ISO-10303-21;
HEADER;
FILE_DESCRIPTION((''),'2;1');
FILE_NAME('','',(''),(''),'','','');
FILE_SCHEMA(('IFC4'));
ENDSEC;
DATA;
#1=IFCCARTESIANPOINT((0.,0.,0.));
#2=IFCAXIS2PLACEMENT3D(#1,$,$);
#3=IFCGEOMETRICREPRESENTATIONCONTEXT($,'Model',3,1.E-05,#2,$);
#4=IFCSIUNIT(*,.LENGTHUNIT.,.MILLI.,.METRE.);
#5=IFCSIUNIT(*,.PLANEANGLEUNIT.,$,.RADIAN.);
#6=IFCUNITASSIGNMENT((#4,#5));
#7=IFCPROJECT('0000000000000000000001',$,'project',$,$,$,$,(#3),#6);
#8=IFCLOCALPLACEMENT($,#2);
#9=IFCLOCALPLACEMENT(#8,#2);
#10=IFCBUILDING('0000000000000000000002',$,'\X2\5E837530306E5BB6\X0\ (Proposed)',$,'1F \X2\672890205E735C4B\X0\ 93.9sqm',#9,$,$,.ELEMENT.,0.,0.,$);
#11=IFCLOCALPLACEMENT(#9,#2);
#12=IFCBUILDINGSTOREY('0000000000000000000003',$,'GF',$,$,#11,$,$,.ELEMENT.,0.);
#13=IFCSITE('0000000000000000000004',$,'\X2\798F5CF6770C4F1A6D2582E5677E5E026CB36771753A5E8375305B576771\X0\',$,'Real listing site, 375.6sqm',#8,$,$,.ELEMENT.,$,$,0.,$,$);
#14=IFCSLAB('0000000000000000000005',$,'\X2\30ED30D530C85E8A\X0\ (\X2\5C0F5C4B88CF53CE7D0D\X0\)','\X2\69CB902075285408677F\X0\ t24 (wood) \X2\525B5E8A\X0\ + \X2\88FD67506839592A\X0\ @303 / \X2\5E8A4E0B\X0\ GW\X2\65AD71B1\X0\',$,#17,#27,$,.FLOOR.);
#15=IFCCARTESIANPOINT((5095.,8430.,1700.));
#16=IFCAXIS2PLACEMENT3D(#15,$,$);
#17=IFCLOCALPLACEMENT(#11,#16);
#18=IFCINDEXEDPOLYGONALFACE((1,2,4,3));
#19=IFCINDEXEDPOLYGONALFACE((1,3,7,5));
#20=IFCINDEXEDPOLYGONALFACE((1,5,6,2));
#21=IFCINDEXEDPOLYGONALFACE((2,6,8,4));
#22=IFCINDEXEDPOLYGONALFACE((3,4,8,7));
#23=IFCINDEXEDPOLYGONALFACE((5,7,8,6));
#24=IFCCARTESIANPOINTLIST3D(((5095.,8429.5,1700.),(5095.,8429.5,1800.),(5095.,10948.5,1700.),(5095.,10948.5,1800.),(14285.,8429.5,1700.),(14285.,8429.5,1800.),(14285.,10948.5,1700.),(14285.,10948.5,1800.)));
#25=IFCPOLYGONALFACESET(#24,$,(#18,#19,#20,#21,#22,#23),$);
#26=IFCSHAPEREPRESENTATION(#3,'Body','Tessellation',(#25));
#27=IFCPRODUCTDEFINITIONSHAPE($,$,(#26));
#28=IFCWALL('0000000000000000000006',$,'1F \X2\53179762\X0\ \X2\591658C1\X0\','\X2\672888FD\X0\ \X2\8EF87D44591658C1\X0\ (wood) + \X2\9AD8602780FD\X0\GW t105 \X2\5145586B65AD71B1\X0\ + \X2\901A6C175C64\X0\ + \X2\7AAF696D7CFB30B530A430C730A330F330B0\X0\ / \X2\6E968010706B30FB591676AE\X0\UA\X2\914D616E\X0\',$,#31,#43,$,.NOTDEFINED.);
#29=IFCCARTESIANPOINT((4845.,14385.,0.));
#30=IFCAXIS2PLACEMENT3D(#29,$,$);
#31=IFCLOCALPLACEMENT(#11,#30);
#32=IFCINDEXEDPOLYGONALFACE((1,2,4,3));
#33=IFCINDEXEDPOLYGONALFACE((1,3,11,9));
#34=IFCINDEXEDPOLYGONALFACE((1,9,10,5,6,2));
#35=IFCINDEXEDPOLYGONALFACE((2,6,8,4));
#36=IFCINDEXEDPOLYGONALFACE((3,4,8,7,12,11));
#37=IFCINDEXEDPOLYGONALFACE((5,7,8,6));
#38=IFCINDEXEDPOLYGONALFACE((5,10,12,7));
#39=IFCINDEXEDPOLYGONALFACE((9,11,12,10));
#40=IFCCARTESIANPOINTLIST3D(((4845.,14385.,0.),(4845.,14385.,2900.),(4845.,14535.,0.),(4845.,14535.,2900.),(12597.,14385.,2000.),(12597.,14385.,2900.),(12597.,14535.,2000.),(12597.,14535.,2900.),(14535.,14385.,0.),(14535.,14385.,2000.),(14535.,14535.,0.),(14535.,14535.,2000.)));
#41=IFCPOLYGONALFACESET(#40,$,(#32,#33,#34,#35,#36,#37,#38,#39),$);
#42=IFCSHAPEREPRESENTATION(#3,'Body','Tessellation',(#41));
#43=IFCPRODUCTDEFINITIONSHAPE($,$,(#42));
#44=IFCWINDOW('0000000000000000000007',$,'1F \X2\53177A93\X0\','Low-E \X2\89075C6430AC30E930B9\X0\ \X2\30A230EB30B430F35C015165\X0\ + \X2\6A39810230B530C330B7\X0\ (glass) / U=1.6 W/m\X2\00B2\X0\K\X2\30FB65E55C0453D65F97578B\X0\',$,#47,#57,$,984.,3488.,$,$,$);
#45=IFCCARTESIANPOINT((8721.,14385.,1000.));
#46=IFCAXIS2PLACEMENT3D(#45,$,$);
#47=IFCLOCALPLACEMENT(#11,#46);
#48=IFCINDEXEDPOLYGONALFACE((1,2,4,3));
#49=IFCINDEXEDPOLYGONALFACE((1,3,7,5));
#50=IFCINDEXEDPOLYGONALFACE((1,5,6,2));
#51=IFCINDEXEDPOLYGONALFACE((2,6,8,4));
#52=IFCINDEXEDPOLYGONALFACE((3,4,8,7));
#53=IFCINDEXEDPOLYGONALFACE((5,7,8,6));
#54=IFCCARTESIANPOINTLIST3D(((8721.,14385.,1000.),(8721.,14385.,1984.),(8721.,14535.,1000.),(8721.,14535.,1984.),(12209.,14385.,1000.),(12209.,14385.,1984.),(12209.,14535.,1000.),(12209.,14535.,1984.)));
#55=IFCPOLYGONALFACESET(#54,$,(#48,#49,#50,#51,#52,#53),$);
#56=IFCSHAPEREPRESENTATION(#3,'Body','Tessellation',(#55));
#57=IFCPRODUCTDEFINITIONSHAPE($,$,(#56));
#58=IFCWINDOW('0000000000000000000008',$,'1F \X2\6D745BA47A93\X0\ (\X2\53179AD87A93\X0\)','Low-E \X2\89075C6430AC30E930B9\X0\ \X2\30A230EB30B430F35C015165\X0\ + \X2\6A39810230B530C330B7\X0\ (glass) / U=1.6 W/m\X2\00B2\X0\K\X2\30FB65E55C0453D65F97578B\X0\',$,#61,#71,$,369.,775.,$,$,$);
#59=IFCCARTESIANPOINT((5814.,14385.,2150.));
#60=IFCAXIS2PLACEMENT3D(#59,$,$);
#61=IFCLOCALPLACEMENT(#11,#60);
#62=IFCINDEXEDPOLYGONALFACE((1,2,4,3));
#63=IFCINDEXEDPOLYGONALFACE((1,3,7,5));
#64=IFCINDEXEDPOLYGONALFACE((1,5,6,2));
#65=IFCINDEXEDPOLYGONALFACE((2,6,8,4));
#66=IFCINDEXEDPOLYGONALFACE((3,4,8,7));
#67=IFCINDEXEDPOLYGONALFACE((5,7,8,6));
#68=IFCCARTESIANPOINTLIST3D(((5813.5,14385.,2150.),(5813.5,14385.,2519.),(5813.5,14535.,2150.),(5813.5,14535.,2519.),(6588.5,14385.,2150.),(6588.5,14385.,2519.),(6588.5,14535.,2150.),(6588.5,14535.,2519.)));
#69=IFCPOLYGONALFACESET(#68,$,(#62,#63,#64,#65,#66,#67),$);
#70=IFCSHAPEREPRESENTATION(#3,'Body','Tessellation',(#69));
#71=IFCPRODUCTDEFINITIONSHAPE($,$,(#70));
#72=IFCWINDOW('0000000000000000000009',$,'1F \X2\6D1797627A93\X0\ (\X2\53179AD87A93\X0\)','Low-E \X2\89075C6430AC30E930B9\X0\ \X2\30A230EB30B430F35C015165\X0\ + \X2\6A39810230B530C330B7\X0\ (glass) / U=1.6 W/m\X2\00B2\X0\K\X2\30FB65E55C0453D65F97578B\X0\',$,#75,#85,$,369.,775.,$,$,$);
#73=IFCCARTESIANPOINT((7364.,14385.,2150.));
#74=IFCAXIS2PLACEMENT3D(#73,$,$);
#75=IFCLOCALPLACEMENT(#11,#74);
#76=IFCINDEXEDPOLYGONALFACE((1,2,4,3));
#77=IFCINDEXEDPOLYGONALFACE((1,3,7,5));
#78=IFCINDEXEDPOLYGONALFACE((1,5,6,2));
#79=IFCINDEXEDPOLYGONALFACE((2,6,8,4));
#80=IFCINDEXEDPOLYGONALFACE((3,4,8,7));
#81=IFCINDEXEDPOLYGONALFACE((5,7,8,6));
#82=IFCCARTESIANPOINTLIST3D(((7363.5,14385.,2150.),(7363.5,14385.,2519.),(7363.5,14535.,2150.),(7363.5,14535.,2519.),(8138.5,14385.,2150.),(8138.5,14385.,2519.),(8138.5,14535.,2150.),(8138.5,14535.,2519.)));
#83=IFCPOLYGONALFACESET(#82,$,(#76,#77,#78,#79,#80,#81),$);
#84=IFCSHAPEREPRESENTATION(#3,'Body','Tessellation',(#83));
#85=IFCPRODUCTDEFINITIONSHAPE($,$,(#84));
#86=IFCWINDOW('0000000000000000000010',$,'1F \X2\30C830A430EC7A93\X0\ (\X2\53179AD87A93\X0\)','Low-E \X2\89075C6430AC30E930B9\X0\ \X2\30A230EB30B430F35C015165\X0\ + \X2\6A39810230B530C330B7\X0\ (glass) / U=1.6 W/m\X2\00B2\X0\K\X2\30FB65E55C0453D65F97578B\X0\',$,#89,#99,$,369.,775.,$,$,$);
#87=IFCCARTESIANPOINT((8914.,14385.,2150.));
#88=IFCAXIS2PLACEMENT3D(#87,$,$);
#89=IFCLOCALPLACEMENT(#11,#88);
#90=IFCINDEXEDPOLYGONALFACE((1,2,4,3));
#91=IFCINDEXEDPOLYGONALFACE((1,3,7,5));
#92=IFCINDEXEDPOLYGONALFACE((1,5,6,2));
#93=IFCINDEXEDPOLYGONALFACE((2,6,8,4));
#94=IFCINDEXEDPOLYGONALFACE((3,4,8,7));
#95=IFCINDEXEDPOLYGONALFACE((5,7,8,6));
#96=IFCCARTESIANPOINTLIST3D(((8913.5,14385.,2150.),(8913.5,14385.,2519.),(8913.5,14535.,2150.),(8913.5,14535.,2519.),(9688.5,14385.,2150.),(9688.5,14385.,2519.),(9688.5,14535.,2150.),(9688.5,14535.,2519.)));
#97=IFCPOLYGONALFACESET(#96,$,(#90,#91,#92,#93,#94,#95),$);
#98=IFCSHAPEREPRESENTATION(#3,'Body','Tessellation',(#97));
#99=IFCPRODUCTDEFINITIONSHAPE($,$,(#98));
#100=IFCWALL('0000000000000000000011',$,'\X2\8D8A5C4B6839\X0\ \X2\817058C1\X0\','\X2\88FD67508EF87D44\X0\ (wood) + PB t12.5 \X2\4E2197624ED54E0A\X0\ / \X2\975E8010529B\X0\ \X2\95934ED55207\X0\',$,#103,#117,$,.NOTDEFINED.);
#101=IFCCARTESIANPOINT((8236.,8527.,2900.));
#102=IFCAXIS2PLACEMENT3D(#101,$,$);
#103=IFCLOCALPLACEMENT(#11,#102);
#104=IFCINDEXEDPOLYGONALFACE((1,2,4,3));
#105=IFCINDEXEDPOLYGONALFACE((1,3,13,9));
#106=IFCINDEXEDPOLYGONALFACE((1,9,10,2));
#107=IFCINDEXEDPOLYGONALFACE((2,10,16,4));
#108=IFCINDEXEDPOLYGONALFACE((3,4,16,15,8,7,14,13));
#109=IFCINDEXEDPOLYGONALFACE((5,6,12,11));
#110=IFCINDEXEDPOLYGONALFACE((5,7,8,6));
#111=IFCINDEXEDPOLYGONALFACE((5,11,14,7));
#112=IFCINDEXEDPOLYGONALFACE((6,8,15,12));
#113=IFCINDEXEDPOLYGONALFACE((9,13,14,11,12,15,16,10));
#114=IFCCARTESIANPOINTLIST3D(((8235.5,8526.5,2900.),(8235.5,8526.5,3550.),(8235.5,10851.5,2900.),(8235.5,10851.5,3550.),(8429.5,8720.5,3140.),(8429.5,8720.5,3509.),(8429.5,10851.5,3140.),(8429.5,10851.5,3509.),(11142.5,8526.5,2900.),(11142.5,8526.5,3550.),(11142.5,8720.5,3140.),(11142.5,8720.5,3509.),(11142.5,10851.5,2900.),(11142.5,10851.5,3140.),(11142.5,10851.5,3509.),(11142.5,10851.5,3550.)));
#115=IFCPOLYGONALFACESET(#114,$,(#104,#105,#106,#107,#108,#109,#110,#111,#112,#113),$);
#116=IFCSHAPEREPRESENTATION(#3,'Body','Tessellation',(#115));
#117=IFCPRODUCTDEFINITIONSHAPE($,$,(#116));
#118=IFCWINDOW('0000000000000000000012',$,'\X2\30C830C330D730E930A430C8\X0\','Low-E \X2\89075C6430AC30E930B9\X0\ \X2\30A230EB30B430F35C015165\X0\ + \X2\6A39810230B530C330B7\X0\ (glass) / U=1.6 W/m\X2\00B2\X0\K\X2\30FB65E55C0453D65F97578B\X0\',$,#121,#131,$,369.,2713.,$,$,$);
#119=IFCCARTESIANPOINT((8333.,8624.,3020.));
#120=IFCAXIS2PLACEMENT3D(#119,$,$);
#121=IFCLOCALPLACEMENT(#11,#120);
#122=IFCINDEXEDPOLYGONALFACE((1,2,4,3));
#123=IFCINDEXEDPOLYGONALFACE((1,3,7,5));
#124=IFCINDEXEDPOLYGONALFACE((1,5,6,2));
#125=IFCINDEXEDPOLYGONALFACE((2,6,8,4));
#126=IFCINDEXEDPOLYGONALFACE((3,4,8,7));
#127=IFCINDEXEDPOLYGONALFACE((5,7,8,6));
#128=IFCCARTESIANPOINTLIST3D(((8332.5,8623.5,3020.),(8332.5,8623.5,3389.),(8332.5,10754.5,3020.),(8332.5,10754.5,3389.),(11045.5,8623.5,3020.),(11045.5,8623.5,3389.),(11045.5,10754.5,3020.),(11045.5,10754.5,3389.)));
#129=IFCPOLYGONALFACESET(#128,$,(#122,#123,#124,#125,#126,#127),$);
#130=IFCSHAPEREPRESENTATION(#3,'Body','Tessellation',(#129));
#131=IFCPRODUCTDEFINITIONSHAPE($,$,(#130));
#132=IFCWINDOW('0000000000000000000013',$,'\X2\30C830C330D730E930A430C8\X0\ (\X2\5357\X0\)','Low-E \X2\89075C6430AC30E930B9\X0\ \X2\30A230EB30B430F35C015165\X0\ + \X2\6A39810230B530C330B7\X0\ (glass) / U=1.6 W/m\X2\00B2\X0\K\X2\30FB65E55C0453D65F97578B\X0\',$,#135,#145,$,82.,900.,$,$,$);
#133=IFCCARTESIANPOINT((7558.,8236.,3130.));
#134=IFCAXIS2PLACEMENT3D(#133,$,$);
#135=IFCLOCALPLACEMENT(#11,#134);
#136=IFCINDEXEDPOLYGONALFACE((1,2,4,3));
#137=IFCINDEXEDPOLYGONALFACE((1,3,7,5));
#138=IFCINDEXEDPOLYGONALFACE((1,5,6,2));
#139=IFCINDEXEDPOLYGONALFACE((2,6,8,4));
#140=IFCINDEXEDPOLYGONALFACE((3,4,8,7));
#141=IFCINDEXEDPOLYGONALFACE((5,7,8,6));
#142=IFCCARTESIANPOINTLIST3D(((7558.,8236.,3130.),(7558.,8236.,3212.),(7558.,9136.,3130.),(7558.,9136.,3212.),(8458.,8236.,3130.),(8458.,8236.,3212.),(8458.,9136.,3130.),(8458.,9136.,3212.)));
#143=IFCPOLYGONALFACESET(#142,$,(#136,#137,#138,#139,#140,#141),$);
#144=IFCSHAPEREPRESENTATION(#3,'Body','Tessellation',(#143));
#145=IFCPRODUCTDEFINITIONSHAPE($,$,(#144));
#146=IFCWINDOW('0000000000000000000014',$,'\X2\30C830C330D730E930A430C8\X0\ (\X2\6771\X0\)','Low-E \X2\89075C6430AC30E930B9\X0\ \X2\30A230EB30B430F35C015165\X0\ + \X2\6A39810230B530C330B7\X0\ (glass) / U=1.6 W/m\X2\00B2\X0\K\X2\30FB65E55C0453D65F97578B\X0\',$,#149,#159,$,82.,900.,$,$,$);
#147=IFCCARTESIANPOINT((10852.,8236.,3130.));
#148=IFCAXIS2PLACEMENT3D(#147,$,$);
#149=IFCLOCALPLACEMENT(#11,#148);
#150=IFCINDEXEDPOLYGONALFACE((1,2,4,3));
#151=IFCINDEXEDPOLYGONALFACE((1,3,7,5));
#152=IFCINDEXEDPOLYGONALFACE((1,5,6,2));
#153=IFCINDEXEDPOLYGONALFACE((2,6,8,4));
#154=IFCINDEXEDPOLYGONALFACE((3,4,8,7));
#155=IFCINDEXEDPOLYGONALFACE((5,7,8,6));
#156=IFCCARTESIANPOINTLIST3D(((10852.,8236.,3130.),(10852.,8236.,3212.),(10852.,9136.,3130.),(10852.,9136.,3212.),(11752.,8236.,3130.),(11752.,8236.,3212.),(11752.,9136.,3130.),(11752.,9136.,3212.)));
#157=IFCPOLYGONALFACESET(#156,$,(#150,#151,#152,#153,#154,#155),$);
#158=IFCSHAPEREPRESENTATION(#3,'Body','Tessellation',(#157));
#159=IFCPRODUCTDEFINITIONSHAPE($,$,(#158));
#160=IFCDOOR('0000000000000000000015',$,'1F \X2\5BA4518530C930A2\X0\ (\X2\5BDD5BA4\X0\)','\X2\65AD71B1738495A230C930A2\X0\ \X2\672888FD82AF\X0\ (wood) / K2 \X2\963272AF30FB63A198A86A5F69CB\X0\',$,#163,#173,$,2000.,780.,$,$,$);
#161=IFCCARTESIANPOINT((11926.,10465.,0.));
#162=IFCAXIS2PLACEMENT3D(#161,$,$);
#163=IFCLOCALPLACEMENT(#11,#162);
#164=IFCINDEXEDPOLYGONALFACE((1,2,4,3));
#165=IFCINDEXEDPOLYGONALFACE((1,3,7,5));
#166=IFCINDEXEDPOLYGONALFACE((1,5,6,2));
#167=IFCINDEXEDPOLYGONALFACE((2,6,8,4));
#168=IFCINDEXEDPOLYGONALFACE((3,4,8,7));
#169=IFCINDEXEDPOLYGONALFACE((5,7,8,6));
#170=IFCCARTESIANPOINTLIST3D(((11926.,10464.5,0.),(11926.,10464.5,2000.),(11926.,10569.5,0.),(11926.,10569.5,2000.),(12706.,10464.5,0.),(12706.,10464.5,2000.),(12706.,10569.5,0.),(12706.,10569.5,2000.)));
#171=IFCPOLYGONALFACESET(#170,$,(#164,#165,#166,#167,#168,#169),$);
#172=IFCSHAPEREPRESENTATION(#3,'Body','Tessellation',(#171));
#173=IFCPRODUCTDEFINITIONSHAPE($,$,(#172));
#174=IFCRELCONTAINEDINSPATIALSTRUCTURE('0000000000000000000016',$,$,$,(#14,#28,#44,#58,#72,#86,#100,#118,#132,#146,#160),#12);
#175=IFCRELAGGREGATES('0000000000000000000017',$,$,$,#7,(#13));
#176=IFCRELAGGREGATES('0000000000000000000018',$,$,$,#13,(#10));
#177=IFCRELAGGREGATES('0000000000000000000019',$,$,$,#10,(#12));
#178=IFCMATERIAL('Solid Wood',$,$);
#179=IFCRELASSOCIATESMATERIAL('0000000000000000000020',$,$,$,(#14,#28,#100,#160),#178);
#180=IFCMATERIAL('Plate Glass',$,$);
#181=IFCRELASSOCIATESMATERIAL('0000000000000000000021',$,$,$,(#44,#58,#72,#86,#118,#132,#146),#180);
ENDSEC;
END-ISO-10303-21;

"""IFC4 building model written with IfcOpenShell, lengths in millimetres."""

from ifc_helpers import new_model, si_unit, frame, frame_2d, origin, place, context, project, spatial, rectangle, extrude, material, element, fill, save


model = new_model("IFC4")

# Units and contexts
model_context = context("Model", 3, precision=1e-05, world=origin())
ifc_project = project(units=[si_unit("LENGTHUNIT", "METRE", prefix="MILLI"), si_unit("PLANEANGLEUNIT", "RADIAN")], contexts=[model_context])

# Site, building, storey
site_placement = place(None, origin())
site = spatial("IfcSite", under=ifc_project, at=site_placement, Name="福島県会津若松市河東町広田字東", ObjectType="Real listing site, 375.6sqm", CompositionType="ELEMENT", RefElevation=0.0)
building_placement = place(site_placement, origin())
building = spatial("IfcBuilding", under=site, at=building_placement, Name="広田の家 (Proposed)", ObjectType="1F 木造平屋 93.9sqm", CompositionType="ELEMENT", ElevationOfRefHeight=0.0, ElevationOfTerrain=0.0)
storey_placement = place(building_placement, origin())
storey = spatial("IfcBuildingStorey", under=building, at=storey_placement, Name="GF", CompositionType="ELEMENT", Elevation=0.0)

# Slab
ifc_material_1 = material(Name="Solid Wood")
slab_placement = place(storey_placement, frame((5095.0, 8430.0, 1700.0)))
element("IfcSlab", 1, at=slab_placement, inside=storey, material=ifc_material_1, Name="ロフト床 (小屋裏収納)", Description="構造用合板 t24 (wood) 剛床 + 製材根太 @303 / 床下 GW断熱", PredefinedType="FLOOR", context=model_context, shape_type="SweptSolid", body=[
    extrude(rectangle(XDim=9190.0, YDim=2519.0, at=frame_2d((4595.0, 1259.0))), frame((5095.0, 8430.0, 1700.0)), (0.0, 0.0, 1.0), 100.0),
])

# Wall, openings, windows
wall_1_placement = place(storey_placement, frame((4845.0, 14385.0, 0.0)))
wall_1 = element("IfcWall", 2, at=wall_1_placement, inside=storey, material=ifc_material_1, Name="1F 北面 外壁", Description="木製 軸組外壁 (wood) + 高性能GW t105 充填断熱 + 通気層 + 窯業系サイディング / 準耐火・外皮UA配慮", PredefinedType="NOTDEFINED", context=model_context, shape_type="SweptSolid", body=[
    extrude(rectangle(XDim=9690.0, YDim=150.0, at=frame_2d((4845.0, 75.0))), frame((4845.0, 14385.0, 0.0)), (0.0, 0.0, 1.0), 2900.0),
])
opening_1_placement = place(storey_placement, frame((8721.0, 14385.0, 1000.0)))
opening_1 = element("IfcOpeningElement", 3, at=opening_1_placement, cuts=wall_1, PredefinedType="NOTDEFINED", context=model_context, shape_type="SweptSolid", body=[
    extrude(rectangle(XDim=3488.0, YDim=150.0, at=frame_2d((1744.0, 75.0))), frame((8721.0, 14385.0, 1000.0)), (0.0, 0.0, 1.0), 984.0),
])
opening_2_placement = place(storey_placement, frame((5814.0, 14385.0, 2150.0)))
opening_2 = element("IfcOpeningElement", 4, at=opening_2_placement, cuts=wall_1, PredefinedType="NOTDEFINED", context=model_context, shape_type="SweptSolid", body=[
    extrude(rectangle(XDim=775.0, YDim=150.0, at=frame_2d((387.0, 75.0))), frame((5814.0, 14385.0, 2150.0)), (0.0, 0.0, 1.0), 369.0),
])
opening_3_placement = place(storey_placement, frame((7364.0, 14385.0, 2150.0)))
opening_3 = element("IfcOpeningElement", 5, at=opening_3_placement, cuts=wall_1, PredefinedType="NOTDEFINED", context=model_context, shape_type="SweptSolid", body=[
    extrude(rectangle(XDim=775.0, YDim=150.0, at=frame_2d((387.0, 75.0))), frame((7364.0, 14385.0, 2150.0)), (0.0, 0.0, 1.0), 369.0),
])
opening_4_placement = place(storey_placement, frame((8914.0, 14385.0, 2150.0)))
opening_4 = element("IfcOpeningElement", 6, at=opening_4_placement, cuts=wall_1, PredefinedType="NOTDEFINED", context=model_context, shape_type="SweptSolid", body=[
    extrude(rectangle(XDim=775.0, YDim=150.0, at=frame_2d((387.0, 75.0))), frame((8914.0, 14385.0, 2150.0)), (0.0, 0.0, 1.0), 369.0),
])
ifc_material_2 = material(Name="Plate Glass")
window_1_placement = place(storey_placement, frame((8721.0, 14385.0, 1000.0)))
window_1 = element("IfcWindow", 7, at=window_1_placement, inside=storey, material=ifc_material_2, Name="1F 北窓", Description="Low-E 複層ガラス アルゴン封入 + 樹脂サッシ (glass) / U=1.6 W/m²K・日射取得型", OverallHeight=984.0, OverallWidth=3488.0, context=model_context, shape_type="SweptSolid", body=[
    extrude(rectangle(XDim=3488.0, YDim=150.0, at=frame_2d((1744.0, 75.0))), frame((8721.0, 14385.0, 1000.0)), (0.0, 0.0, 1.0), 984.0),
])
fill(opening_1, window_1)
window_2_placement = place(storey_placement, frame((5814.0, 14385.0, 2150.0)))
window_2 = element("IfcWindow", 8, at=window_2_placement, inside=storey, material=ifc_material_2, Name="1F 浴室窓 (北高窓)", Description="Low-E 複層ガラス アルゴン封入 + 樹脂サッシ (glass) / U=1.6 W/m²K・日射取得型", OverallHeight=369.0, OverallWidth=775.0, context=model_context, shape_type="SweptSolid", body=[
    extrude(rectangle(XDim=775.0, YDim=150.0, at=frame_2d((387.0, 75.0))), frame((5814.0, 14385.0, 2150.0)), (0.0, 0.0, 1.0), 369.0),
])
fill(opening_2, window_2)
window_3_placement = place(storey_placement, frame((7364.0, 14385.0, 2150.0)))
window_3 = element("IfcWindow", 9, at=window_3_placement, inside=storey, material=ifc_material_2, Name="1F 洗面窓 (北高窓)", Description="Low-E 複層ガラス アルゴン封入 + 樹脂サッシ (glass) / U=1.6 W/m²K・日射取得型", OverallHeight=369.0, OverallWidth=775.0, context=model_context, shape_type="SweptSolid", body=[
    extrude(rectangle(XDim=775.0, YDim=150.0, at=frame_2d((387.0, 75.0))), frame((7364.0, 14385.0, 2150.0)), (0.0, 0.0, 1.0), 369.0),
])
fill(opening_3, window_3)
window_4_placement = place(storey_placement, frame((8914.0, 14385.0, 2150.0)))
window_4 = element("IfcWindow", 10, at=window_4_placement, inside=storey, material=ifc_material_2, Name="1F トイレ窓 (北高窓)", Description="Low-E 複層ガラス アルゴン封入 + 樹脂サッシ (glass) / U=1.6 W/m²K・日射取得型", OverallHeight=369.0, OverallWidth=775.0, context=model_context, shape_type="SweptSolid", body=[
    extrude(rectangle(XDim=775.0, YDim=150.0, at=frame_2d((387.0, 75.0))), frame((8914.0, 14385.0, 2150.0)), (0.0, 0.0, 1.0), 369.0),
])
fill(opening_4, window_4)

# Wall, openings, windows
wall_2_placement = place(storey_placement, frame((8236.0, 8527.0, 2900.0)))
wall_2 = element("IfcWall", 11, at=wall_2_placement, inside=storey, material=ifc_material_1, Name="越屋根 腰壁", Description="製材軸組 (wood) + PB t12.5 両面仕上 / 非耐力 間仕切", PredefinedType="NOTDEFINED", context=model_context, shape_type="SweptSolid", body=[
    extrude(rectangle(XDim=2907.0, YDim=2325.0, at=frame_2d((1453.0, 1162.0))), frame((8236.0, 8527.0, 2900.0)), (0.0, 0.0, 1.0), 650.0),
])
opening_5_placement = place(storey_placement, frame((8333.0, 8624.0, 3020.0)))
opening_5 = element("IfcOpeningElement", 12, at=opening_5_placement, cuts=wall_2, PredefinedType="NOTDEFINED", context=model_context, shape_type="SweptSolid", body=[
    extrude(rectangle(XDim=2713.0, YDim=2131.0, at=frame_2d((1356.0, 1065.0))), frame((8333.0, 8624.0, 3020.0)), (0.0, 0.0, 1.0), 369.0),
])
opening_6_placement = place(storey_placement, frame((7558.0, 8236.0, 3130.0)))
opening_6 = element("IfcOpeningElement", 13, at=opening_6_placement, cuts=wall_2, PredefinedType="NOTDEFINED", context=model_context, shape_type="SweptSolid", body=[
    extrude(rectangle(XDim=900.0, YDim=900.0, at=frame_2d((450.0, 450.0))), frame((7558.0, 8236.0, 3130.0)), (0.0, 0.0, 1.0), 82.0),
])
opening_7_placement = place(storey_placement, frame((10852.0, 8236.0, 3130.0)))
opening_7 = element("IfcOpeningElement", 14, at=opening_7_placement, cuts=wall_2, PredefinedType="NOTDEFINED", context=model_context, shape_type="SweptSolid", body=[
    extrude(rectangle(XDim=900.0, YDim=900.0, at=frame_2d((450.0, 450.0))), frame((10852.0, 8236.0, 3130.0)), (0.0, 0.0, 1.0), 82.0),
])
window_5_placement = place(storey_placement, frame((8333.0, 8624.0, 3020.0)))
window_5 = element("IfcWindow", 15, at=window_5_placement, inside=storey, material=ifc_material_2, Name="トップライト", Description="Low-E 複層ガラス アルゴン封入 + 樹脂サッシ (glass) / U=1.6 W/m²K・日射取得型", OverallHeight=369.0, OverallWidth=2713.0, context=model_context, shape_type="SweptSolid", body=[
    extrude(rectangle(XDim=2713.0, YDim=2131.0, at=frame_2d((1356.0, 1065.0))), frame((8333.0, 8624.0, 3020.0)), (0.0, 0.0, 1.0), 369.0),
])
fill(opening_5, window_5)
window_6_placement = place(storey_placement, frame((7558.0, 8236.0, 3130.0)))
window_6 = element("IfcWindow", 16, at=window_6_placement, inside=storey, material=ifc_material_2, Name="トップライト (南)", Description="Low-E 複層ガラス アルゴン封入 + 樹脂サッシ (glass) / U=1.6 W/m²K・日射取得型", OverallHeight=82.0, OverallWidth=900.0, context=model_context, shape_type="SweptSolid", body=[
    extrude(rectangle(XDim=900.0, YDim=900.0, at=frame_2d((450.0, 450.0))), frame((7558.0, 8236.0, 3130.0)), (0.0, 0.0, 1.0), 82.0),
])
fill(opening_6, window_6)
window_7_placement = place(storey_placement, frame((10852.0, 8236.0, 3130.0)))
window_7 = element("IfcWindow", 17, at=window_7_placement, inside=storey, material=ifc_material_2, Name="トップライト (東)", Description="Low-E 複層ガラス アルゴン封入 + 樹脂サッシ (glass) / U=1.6 W/m²K・日射取得型", OverallHeight=82.0, OverallWidth=900.0, context=model_context, shape_type="SweptSolid", body=[
    extrude(rectangle(XDim=900.0, YDim=900.0, at=frame_2d((450.0, 450.0))), frame((10852.0, 8236.0, 3130.0)), (0.0, 0.0, 1.0), 82.0),
])
fill(opening_7, window_7)

# Door
door_1_placement = place(storey_placement, frame((11926.0, 10465.0, 0.0)))
element("IfcDoor", 18, at=door_1_placement, inside=storey, material=ifc_material_1, Name="1F 室内ドア (寝室)", Description="断熱玄関ドア 木製芯 (wood) / K2 防犯・採風機構", OverallHeight=2000.0, OverallWidth=780.0, context=model_context, shape_type="SweptSolid", body=[
    extrude(rectangle(XDim=780.0, YDim=105.0, at=frame_2d((390.0, 52.0))), frame((11926.0, 10465.0, 0.0)), (0.0, 0.0, 1.0), 2000.0),
])

save(model, "model.ifc")
